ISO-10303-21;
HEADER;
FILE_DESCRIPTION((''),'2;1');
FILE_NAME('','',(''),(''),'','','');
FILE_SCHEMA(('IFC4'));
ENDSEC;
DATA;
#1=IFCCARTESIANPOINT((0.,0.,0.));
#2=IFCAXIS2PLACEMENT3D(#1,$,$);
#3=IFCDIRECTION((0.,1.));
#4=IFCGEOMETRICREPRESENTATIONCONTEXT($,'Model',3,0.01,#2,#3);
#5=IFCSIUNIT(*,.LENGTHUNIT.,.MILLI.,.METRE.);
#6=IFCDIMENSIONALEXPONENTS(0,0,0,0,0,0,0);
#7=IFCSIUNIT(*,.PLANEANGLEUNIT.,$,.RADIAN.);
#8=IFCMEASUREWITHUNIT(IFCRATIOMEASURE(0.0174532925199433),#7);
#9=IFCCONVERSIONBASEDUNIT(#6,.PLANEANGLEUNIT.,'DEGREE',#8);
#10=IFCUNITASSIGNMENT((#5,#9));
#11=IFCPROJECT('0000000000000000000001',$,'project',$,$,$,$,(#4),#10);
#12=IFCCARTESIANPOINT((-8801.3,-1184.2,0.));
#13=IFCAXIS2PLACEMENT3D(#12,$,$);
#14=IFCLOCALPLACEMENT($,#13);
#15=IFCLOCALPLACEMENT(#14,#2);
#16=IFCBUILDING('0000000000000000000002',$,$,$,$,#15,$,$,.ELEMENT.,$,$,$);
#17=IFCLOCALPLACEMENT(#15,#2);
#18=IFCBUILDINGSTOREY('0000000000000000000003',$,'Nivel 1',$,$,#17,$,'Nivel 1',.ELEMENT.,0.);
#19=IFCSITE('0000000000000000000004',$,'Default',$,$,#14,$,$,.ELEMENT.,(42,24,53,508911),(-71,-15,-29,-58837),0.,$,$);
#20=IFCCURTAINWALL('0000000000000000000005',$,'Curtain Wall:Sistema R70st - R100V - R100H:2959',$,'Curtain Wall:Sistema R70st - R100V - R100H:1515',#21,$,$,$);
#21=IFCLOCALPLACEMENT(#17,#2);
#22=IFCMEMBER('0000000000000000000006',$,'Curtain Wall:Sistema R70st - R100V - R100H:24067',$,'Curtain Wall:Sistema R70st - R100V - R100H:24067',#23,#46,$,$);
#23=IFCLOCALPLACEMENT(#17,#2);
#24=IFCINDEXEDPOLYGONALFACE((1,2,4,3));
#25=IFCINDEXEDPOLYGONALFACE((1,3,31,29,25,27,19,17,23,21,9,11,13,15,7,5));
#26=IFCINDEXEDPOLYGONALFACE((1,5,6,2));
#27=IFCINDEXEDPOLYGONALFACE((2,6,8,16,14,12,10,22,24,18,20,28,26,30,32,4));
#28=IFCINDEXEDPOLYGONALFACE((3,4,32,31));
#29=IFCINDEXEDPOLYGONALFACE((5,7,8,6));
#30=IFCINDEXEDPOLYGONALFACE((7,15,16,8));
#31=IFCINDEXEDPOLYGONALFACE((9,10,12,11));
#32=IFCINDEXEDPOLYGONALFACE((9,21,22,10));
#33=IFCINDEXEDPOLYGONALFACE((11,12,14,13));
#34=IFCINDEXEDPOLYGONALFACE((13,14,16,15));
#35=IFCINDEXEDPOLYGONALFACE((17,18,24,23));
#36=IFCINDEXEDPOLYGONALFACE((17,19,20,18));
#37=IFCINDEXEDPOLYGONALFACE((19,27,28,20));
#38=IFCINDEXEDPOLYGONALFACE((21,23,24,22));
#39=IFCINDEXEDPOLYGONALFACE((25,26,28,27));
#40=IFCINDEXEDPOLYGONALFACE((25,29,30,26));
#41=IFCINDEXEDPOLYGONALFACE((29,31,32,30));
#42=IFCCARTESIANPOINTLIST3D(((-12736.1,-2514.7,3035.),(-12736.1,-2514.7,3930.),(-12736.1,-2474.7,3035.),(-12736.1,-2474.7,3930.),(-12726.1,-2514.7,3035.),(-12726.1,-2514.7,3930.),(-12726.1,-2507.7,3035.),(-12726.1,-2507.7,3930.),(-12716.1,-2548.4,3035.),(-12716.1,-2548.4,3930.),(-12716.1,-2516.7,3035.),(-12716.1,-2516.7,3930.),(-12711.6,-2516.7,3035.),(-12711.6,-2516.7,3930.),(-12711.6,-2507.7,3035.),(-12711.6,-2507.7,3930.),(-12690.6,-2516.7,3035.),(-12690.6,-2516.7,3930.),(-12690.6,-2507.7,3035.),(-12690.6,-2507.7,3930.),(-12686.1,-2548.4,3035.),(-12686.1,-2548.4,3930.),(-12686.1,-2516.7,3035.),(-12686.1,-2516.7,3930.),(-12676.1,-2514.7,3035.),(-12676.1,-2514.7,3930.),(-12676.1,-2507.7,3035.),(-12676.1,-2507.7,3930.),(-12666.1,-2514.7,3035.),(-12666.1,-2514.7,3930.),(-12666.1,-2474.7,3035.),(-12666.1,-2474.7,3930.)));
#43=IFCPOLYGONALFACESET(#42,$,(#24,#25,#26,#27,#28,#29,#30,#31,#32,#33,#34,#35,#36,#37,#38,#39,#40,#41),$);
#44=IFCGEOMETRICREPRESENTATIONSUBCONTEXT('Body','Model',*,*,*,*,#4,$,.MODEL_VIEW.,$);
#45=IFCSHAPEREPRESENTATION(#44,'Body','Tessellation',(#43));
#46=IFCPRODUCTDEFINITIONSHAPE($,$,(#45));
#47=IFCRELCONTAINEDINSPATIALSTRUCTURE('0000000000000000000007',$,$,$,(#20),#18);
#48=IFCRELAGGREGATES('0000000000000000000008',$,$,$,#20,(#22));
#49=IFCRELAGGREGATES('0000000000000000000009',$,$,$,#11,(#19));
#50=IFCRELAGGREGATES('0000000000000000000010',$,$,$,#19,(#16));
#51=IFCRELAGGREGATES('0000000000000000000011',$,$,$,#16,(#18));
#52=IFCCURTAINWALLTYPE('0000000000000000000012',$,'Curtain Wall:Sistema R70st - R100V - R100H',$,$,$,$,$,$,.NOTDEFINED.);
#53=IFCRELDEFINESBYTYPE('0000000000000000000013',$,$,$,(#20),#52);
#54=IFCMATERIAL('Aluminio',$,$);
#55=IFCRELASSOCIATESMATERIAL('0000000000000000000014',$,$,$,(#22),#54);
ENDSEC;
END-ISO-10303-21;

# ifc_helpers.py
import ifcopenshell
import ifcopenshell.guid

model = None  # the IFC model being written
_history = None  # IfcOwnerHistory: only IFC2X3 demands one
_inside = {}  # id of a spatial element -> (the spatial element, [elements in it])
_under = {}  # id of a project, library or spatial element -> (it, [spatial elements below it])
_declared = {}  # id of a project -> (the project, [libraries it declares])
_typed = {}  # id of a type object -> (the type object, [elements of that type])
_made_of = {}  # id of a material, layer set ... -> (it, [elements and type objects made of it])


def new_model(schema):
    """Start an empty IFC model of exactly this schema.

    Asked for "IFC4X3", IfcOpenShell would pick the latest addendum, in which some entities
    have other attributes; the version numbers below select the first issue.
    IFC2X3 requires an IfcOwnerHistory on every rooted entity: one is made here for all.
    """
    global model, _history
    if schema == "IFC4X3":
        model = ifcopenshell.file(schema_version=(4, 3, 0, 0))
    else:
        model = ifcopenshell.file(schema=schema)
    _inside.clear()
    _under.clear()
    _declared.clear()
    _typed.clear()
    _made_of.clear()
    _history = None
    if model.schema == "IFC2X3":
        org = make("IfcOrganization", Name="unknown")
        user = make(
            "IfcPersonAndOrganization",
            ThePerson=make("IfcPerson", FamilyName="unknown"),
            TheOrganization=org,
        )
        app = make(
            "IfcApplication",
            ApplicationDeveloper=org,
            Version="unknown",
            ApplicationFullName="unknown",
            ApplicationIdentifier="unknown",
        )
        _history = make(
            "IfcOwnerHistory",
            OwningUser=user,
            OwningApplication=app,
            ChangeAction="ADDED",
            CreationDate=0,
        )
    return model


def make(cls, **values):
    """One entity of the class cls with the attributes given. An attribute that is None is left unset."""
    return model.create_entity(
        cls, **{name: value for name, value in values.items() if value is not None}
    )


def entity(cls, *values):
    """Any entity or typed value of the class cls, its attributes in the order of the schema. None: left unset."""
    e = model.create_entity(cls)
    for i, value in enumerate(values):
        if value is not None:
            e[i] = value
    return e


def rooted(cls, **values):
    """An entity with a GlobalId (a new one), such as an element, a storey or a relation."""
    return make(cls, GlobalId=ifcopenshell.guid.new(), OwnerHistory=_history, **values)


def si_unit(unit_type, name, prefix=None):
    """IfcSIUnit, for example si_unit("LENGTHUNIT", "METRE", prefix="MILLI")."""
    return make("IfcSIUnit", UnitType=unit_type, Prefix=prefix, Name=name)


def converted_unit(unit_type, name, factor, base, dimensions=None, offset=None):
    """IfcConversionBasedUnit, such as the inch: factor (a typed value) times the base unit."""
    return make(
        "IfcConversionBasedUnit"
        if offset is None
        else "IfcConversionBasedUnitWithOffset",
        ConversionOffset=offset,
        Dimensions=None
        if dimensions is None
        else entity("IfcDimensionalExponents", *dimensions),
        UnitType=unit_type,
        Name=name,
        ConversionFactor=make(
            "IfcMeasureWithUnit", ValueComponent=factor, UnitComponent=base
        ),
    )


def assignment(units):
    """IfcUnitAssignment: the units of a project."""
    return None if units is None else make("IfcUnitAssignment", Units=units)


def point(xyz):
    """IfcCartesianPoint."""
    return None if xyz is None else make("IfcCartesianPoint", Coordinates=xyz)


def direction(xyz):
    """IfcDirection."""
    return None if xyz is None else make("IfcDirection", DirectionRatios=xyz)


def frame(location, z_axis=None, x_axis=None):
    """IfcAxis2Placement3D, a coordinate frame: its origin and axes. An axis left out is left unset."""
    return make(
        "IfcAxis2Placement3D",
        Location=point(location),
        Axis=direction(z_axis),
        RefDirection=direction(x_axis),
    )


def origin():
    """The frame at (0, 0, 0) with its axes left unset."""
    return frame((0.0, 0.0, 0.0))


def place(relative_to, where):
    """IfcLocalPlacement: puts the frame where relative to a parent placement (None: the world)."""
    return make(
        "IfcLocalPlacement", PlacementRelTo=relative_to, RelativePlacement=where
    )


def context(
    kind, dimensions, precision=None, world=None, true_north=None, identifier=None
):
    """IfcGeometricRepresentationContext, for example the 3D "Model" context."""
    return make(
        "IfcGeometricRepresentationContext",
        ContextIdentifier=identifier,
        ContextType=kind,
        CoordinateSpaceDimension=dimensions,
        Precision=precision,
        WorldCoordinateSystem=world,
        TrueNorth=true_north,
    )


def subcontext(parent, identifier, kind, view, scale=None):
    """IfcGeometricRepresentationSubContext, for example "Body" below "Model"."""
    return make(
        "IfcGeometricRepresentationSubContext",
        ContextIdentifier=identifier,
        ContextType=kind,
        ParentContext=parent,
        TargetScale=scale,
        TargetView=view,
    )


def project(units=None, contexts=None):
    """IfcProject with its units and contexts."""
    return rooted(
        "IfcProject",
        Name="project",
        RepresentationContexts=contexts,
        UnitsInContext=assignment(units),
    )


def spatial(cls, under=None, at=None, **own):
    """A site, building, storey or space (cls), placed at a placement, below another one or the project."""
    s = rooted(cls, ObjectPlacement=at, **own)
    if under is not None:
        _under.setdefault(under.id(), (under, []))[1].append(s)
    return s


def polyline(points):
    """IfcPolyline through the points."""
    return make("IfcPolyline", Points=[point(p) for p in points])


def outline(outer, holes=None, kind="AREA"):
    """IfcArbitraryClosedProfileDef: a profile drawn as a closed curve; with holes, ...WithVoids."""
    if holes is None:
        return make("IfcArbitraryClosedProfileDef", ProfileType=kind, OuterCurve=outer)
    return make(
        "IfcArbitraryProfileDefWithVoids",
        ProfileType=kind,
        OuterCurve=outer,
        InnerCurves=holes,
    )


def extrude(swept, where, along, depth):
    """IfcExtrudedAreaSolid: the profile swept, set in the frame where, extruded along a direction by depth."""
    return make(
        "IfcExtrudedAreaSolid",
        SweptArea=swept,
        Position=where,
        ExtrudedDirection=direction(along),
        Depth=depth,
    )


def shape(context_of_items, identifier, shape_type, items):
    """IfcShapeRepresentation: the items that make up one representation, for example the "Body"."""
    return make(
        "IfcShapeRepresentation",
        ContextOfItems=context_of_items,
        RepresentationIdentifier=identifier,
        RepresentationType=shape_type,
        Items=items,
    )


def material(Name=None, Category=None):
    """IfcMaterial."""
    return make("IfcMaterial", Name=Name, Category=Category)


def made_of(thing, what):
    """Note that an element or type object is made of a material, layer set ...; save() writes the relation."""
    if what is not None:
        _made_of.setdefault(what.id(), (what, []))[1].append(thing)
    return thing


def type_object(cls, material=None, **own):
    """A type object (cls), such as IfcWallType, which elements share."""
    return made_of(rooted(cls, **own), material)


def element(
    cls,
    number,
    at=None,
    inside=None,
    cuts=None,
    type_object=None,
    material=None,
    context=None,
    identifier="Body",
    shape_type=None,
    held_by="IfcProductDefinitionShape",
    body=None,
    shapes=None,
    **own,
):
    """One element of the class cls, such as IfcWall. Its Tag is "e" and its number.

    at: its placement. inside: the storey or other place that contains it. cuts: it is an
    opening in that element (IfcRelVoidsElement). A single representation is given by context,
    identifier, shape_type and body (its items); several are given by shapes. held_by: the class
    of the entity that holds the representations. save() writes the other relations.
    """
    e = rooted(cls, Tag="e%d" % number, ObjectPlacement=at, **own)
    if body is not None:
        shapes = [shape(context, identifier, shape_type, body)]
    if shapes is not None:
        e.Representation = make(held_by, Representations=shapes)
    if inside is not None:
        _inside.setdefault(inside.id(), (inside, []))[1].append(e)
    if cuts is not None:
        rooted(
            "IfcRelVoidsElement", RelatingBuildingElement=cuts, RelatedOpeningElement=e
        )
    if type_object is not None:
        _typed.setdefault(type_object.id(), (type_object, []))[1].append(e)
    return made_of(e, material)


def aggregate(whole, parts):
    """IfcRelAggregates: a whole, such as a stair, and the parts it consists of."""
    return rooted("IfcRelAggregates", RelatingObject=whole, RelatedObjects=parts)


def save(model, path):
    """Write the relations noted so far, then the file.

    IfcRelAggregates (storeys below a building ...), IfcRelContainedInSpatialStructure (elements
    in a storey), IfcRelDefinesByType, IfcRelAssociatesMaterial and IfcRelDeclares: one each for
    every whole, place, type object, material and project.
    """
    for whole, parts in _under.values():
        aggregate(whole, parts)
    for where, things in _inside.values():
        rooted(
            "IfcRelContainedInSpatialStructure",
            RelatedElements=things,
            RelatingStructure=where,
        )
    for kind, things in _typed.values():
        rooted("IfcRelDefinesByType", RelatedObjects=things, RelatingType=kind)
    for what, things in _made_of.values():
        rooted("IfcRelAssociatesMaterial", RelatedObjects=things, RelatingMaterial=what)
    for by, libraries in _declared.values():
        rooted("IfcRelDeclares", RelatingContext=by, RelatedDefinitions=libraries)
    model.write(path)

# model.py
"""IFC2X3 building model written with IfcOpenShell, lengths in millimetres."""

from ifc_helpers import new_model, entity, si_unit, converted_unit, direction, frame, origin, place, context, subcontext, project, spatial, polyline, outline, extrude, material, type_object, element, aggregate, save


model = new_model("IFC2X3")

# Units and contexts
model_context = context("Model", 3, precision=0.01, world=origin(), true_north=direction((0.0, 1.0)))
body_context = subcontext(model_context, "Body", "Model", "MODEL_VIEW")
ifc_project = project(units=[si_unit("LENGTHUNIT", "METRE", prefix="MILLI"), converted_unit("PLANEANGLEUNIT", "DEGREE", entity("IfcRatioMeasure", 0.0174532925199433), si_unit("PLANEANGLEUNIT", "RADIAN"), dimensions=[0, 0, 0, 0, 0, 0, 0])], contexts=[model_context])

# Site, building, storey
site_placement = place(None, frame((-8801.3, -1184.2, 0.0)))
site = spatial("IfcSite", under=ifc_project, at=site_placement, Name="Default", CompositionType="ELEMENT", RefLatitude=(42, 24, 53, 508911), RefLongitude=(-71, -15, -29, -58837), RefElevation=0.0)
building_placement = place(site_placement, origin())
building = spatial("IfcBuilding", under=site, at=building_placement, CompositionType="ELEMENT")
storey_placement = place(building_placement, origin())
storey = spatial("IfcBuildingStorey", under=building, at=storey_placement, Name="Nivel 1", LongName="Nivel 1", CompositionType="ELEMENT", Elevation=0.0)

# Curtain wall, member
curtain_wall_type = type_object("IfcCurtainWallType", Name="Curtain Wall:Sistema R70st - R100V - R100H", PredefinedType="NOTDEFINED")
curtain_wall_placement = place(storey_placement, origin())
curtain_wall = element("IfcCurtainWall", 1, at=curtain_wall_placement, inside=storey, type_object=curtain_wall_type, Name="Curtain Wall:Sistema R70st - R100V - R100H:2959", ObjectType="Curtain Wall:Sistema R70st - R100V - R100H:1515")
ifc_material = material(Name="Aluminio")
member_1_placement = place(curtain_wall_placement, origin())
member_1 = element("IfcMember", 2, at=member_1_placement, material=ifc_material, Name="Curtain Wall:Sistema R70st - R100V - R100H:24067", ObjectType="Curtain Wall:Sistema R70st - R100V - R100H:24067", context=body_context, shape_type="SweptSolid", body=[
    extrude(outline(polyline([(-15.0, -35.7), (15.0, -35.7), (15.0, -4.0), (10.5, -4.0), (10.5, 5.0), (25.0, 5.0), (25.0, -2.0), (35.0, -2.0), (35.0, 38.0), (-35.0, 38.0), (-35.0, -2.0), (-25.0, -2.0), (-25.0, 5.0), (-10.5, 5.0), (-10.5, -4.0), (-15.0, -4.0), (-15.0, -35.7)])), frame((-12701.1, -2512.7, 3930.0), z_axis=(0.0, 0.0, -1.0), x_axis=(-1.0, 0.0, 0.0)), (0.0, 0.0, 1.0), 895.0),
])
aggregate(curtain_wall, [member_1])

save(model, "model.ifc")
